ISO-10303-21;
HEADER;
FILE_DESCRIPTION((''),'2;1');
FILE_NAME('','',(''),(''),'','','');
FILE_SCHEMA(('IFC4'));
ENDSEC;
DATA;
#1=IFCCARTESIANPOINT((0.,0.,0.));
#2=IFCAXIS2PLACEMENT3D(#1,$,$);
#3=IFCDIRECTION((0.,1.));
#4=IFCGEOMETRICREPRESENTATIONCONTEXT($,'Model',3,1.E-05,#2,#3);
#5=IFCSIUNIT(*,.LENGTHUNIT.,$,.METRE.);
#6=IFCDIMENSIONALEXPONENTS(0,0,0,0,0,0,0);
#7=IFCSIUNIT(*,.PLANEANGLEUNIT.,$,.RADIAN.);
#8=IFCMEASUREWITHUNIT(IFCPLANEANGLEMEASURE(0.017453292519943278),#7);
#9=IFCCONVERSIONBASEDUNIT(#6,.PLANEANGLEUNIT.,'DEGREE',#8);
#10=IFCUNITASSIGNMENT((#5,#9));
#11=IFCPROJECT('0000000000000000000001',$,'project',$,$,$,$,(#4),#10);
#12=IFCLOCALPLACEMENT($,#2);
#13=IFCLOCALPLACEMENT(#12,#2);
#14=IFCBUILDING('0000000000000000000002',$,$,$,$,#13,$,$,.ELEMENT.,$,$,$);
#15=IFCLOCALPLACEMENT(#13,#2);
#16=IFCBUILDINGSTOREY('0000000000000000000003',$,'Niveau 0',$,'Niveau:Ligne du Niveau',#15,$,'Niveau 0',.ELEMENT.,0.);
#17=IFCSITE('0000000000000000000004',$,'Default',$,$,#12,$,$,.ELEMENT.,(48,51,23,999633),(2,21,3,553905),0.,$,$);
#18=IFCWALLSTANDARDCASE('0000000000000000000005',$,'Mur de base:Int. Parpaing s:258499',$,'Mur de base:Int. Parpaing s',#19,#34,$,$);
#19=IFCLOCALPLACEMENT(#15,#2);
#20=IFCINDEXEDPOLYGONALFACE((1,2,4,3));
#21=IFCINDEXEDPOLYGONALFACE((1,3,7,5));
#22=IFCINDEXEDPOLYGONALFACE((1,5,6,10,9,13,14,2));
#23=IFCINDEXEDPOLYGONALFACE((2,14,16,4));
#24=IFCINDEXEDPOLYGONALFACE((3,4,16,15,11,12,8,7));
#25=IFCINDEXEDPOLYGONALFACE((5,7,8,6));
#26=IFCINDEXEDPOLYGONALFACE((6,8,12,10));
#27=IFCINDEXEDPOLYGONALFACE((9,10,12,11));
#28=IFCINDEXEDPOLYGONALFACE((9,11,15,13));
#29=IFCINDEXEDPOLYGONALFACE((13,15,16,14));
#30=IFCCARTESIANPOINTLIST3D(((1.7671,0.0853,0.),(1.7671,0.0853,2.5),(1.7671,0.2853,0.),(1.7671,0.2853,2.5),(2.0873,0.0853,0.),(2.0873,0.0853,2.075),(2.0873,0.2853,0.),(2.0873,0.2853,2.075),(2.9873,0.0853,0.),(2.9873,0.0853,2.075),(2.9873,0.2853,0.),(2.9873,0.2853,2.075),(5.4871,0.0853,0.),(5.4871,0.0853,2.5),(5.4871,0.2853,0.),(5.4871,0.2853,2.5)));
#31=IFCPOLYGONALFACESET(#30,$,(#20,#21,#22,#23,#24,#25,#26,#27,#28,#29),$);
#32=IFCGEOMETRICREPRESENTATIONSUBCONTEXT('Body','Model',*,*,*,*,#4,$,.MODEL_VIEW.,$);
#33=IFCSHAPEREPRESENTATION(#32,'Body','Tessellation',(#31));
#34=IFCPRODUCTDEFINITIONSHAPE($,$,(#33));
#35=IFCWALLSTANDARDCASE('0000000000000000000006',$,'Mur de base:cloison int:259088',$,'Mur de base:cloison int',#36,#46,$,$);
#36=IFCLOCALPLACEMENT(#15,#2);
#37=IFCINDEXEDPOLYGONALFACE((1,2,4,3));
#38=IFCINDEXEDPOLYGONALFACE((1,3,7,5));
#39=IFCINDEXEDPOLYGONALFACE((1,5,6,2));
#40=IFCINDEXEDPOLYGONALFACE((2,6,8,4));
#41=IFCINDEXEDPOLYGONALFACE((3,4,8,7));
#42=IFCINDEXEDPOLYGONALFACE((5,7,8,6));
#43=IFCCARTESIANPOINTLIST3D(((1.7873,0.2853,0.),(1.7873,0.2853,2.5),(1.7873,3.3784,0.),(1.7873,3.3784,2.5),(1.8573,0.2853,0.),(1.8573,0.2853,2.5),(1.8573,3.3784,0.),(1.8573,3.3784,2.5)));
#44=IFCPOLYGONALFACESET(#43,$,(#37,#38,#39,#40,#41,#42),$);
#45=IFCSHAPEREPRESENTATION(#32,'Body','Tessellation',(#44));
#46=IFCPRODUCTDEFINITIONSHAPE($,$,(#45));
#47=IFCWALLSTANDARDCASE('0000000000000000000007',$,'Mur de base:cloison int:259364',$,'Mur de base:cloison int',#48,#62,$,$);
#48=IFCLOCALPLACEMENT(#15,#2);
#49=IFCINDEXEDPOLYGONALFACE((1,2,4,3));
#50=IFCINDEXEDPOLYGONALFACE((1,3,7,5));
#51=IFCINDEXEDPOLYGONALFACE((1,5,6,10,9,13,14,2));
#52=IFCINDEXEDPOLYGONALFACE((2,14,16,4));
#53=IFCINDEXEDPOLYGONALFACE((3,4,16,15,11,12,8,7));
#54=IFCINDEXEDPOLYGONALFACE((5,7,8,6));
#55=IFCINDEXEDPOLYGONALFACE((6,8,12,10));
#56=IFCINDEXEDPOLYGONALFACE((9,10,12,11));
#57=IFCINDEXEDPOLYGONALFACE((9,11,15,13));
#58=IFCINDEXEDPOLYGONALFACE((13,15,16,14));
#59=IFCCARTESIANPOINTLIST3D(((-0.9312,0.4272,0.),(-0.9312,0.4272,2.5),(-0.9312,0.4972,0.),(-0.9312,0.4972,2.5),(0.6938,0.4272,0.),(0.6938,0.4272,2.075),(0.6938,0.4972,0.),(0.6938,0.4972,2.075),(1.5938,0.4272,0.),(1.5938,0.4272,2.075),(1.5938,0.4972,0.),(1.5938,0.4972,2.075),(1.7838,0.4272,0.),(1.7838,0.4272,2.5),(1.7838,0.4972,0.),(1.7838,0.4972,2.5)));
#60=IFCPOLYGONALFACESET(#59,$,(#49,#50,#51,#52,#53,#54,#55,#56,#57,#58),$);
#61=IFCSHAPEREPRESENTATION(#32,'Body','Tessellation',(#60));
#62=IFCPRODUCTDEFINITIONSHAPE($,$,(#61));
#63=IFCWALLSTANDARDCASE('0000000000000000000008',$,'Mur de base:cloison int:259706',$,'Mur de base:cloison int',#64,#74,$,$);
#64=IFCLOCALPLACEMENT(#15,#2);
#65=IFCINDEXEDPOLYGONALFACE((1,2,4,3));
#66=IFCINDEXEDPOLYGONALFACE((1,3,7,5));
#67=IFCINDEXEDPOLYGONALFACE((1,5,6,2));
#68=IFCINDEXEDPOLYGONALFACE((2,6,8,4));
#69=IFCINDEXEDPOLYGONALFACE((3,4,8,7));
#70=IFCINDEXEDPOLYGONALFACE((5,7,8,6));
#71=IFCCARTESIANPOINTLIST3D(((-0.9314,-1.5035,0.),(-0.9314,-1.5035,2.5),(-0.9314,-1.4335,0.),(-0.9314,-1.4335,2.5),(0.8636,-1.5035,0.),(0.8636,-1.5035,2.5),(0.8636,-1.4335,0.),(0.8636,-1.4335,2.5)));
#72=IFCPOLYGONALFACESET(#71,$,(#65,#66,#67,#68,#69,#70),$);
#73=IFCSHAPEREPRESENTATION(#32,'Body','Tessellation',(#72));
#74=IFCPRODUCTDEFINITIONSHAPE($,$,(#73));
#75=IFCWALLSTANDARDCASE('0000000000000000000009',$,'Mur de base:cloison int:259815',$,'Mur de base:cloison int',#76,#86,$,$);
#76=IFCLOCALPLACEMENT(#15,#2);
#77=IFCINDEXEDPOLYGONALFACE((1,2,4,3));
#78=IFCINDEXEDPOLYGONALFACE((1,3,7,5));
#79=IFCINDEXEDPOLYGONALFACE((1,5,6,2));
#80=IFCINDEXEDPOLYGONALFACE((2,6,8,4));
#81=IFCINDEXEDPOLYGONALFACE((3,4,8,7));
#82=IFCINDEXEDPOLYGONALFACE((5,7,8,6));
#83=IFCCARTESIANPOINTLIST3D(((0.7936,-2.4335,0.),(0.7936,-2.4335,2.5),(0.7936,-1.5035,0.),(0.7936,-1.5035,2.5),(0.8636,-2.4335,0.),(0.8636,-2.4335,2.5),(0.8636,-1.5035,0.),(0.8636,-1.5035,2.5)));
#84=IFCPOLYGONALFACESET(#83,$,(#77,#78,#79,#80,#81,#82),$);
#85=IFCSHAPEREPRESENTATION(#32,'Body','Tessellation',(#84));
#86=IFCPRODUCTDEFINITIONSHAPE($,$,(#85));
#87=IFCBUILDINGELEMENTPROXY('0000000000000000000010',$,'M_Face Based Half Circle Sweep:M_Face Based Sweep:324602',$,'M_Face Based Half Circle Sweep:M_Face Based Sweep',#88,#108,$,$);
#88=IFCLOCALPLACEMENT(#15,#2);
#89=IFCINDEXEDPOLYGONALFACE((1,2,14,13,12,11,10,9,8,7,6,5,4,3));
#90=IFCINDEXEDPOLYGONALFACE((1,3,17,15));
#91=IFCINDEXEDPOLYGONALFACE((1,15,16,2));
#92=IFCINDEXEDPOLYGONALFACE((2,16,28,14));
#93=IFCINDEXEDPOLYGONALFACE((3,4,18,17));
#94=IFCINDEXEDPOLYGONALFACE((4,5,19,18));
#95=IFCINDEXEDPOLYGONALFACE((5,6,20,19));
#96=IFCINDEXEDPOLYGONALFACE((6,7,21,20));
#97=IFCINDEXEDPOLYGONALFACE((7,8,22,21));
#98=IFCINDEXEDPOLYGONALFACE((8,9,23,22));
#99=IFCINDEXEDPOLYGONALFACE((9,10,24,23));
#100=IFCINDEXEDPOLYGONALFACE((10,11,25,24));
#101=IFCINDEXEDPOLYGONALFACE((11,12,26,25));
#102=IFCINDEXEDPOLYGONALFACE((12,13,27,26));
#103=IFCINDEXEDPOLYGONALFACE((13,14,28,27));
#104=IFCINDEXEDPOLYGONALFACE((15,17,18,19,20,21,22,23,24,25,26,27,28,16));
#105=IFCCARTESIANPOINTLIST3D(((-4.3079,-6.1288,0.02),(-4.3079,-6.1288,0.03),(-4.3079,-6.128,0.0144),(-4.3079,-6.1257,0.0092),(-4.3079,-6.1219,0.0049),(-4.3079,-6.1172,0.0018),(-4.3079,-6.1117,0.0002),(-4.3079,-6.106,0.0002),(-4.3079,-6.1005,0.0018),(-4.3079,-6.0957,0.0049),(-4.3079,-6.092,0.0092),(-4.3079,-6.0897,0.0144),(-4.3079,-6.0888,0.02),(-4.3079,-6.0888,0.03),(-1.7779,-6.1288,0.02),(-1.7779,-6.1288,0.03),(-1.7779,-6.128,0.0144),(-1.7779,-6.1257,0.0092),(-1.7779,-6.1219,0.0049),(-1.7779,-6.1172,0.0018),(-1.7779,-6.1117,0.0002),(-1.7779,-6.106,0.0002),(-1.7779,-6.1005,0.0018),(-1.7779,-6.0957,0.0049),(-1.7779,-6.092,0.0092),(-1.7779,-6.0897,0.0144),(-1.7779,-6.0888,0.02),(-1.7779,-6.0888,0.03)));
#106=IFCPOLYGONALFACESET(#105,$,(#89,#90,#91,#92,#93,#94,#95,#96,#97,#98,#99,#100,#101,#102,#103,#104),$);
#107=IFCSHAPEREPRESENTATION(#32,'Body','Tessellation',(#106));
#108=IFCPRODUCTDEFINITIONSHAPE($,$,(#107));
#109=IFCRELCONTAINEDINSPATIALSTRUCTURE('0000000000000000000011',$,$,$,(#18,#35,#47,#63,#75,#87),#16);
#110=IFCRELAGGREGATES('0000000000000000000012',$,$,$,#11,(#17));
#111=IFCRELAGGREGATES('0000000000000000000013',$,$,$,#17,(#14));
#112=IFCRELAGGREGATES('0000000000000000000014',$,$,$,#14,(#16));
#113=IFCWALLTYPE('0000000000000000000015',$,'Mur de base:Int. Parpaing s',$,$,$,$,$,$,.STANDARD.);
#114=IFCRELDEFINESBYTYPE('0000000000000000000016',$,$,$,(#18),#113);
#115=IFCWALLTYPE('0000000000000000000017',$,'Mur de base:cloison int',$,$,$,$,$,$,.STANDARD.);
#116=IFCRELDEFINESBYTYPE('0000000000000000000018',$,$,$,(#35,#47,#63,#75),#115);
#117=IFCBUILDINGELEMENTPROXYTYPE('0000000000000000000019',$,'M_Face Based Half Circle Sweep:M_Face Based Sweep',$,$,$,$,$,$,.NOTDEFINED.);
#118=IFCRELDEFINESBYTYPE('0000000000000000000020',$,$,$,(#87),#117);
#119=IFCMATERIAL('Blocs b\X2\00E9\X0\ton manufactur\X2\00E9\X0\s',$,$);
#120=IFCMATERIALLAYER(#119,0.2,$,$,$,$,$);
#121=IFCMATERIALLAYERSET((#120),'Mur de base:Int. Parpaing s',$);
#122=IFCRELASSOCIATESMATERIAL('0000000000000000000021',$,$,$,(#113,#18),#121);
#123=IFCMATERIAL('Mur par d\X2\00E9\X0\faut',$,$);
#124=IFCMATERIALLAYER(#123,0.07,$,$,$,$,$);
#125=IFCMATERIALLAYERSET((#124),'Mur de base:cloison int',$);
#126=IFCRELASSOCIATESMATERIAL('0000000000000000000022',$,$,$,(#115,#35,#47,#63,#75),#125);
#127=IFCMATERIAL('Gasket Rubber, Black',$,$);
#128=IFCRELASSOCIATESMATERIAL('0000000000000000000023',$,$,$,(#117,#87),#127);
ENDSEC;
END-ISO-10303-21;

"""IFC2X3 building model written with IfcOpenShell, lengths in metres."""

from ifc_helpers import new_model, entity, si_unit, converted_unit, direction, frame, frame_2d, origin, place, context, subcontext, project, spatial, polyline, circle_curve, parameter, trimmed, segment, composite_curve, rectangle, outline, extrude, source, transform, mapped, material, layer, layer_set, layer_usage, type_object, type_shapes, element, save


model = new_model("IFC2X3")

# Units and contexts
model_context = context("Model", 3, precision=1e-05, world=origin(), true_north=direction((0.0, 1.0)))
body_context = subcontext(model_context, "Body", "Model", "MODEL_VIEW")
ifc_project = project(units=[si_unit("LENGTHUNIT", "METRE"), converted_unit("PLANEANGLEUNIT", "DEGREE", entity("IfcPlaneAngleMeasure", 0.017453292519943278), si_unit("PLANEANGLEUNIT", "RADIAN"), dimensions=[0, 0, 0, 0, 0, 0, 0])], contexts=[model_context])

# Site, building, storey
site_placement = place(None, origin())
site = spatial("IfcSite", under=ifc_project, at=site_placement, Name="Default", CompositionType="ELEMENT", RefLatitude=(48, 51, 23, 999633), RefLongitude=(2, 21, 3, 553905), RefElevation=0.0)
building_placement = place(site_placement, origin())
building = spatial("IfcBuilding", under=site, at=building_placement, CompositionType="ELEMENT")
storey_placement = place(building_placement, origin())
storey = spatial("IfcBuildingStorey", under=building, at=storey_placement, Name="Niveau 0", ObjectType="Niveau:Ligne du Niveau", LongName="Niveau 0", CompositionType="ELEMENT", Elevation=0.0)

# Shared definitions
ifc_material_1 = material(Name="Blocs béton manufacturés")

# Wall, opening
ifc_layer_1 = layer(ifc_material_1, 0.2)
ifc_layer_set_1 = layer_set([ifc_layer_1], Name="Mur de base:Int. Parpaing s")
ifc_layer_usage_1 = layer_usage(ifc_layer_set_1, "AXIS2", "POSITIVE", -0.1)
wall_type_1 = type_object("IfcWallType", Name="Mur de base:Int. Parpaing s", PredefinedType="STANDARD", material=ifc_layer_set_1)
wall_1_placement = place(storey_placement, frame((1.7671, 0.1853, 0.0)))
wall_1 = element("IfcWallStandardCase", 1, at=wall_1_placement, inside=storey, type_object=wall_type_1, material=ifc_layer_usage_1, Name="Mur de base:Int. Parpaing s:258499", ObjectType="Mur de base:Int. Parpaing s", context=body_context, shape_type="SweptSolid", body=[
    extrude(rectangle(XDim=3.72, YDim=0.2, at=frame_2d((1.86, 0.0), x_axis=(-1.0, 0.0))), origin(), (0.0, 0.0, 1.0), 2.5),
])
opening_1_placement = place(wall_1_placement, frame((1.2201, 0.1, 0.0)))
element("IfcOpeningElement", 2, at=opening_1_placement, cuts=wall_1, ObjectType="Opening", context=body_context, shape_type="SweptSolid", body=[
    extrude(rectangle(XDim=2.075, YDim=0.9, at=frame_2d((1.0375, 0.45), x_axis=(1.0, 0.0))), frame((0.0, 0.0, 0.0), z_axis=(0.0, -1.0, 0.0), x_axis=(0.0, 0.0, 1.0)), (0.0, 0.0, 1.0), 0.2),
])

# Wall
ifc_material_2 = material(Name="Mur par défaut")
ifc_layer_2 = layer(ifc_material_2, 0.07)
ifc_layer_set_2 = layer_set([ifc_layer_2], Name="Mur de base:cloison int")
ifc_layer_usage_2 = layer_usage(ifc_layer_set_2, "AXIS2", "POSITIVE", -0.035)
wall_type_2 = type_object("IfcWallType", Name="Mur de base:cloison int", PredefinedType="STANDARD", material=ifc_layer_set_2)
wall_2_placement = place(storey_placement, frame((1.8223, 3.3784, 0.0), z_axis=(0.0, 0.0, 1.0), x_axis=(0.0, -1.0, 0.0)))
element("IfcWallStandardCase", 3, at=wall_2_placement, inside=storey, type_object=wall_type_2, material=ifc_layer_usage_2, Name="Mur de base:cloison int:259088", ObjectType="Mur de base:cloison int", context=body_context, shape_type="SweptSolid", body=[
    extrude(rectangle(XDim=3.0931, YDim=0.07, at=frame_2d((1.5465, 0.0), x_axis=(-1.0, 0.0))), origin(), (0.0, 0.0, 1.0), 2.5),
])

# Wall, opening
ifc_layer_usage_3 = layer_usage(ifc_layer_set_2, "AXIS2", "POSITIVE", -0.035)
wall_3_placement = place(storey_placement, frame((1.7838, 0.4622, 0.0), z_axis=(0.0, 0.0, 1.0), x_axis=(-1.0, 0.0, 0.0)))
wall_3 = element("IfcWallStandardCase", 4, at=wall_3_placement, inside=storey, type_object=wall_type_2, material=ifc_layer_usage_3, Name="Mur de base:cloison int:259364", ObjectType="Mur de base:cloison int", context=body_context, shape_type="SweptSolid", body=[
    extrude(rectangle(XDim=2.715, YDim=0.07, at=frame_2d((1.3575, 0.0), x_axis=(-1.0, 0.0))), origin(), (0.0, 0.0, 1.0), 2.5),
])
opening_2_placement = place(wall_3_placement, frame((0.19, -0.035, 0.0)))
element("IfcOpeningElement", 5, at=opening_2_placement, cuts=wall_3, ObjectType="Opening", context=body_context, shape_type="SweptSolid", body=[
    extrude(rectangle(XDim=2.075, YDim=0.9, at=frame_2d((1.0375, 0.45), x_axis=(1.0, 0.0))), frame((0.0, 0.0, 0.0), z_axis=(0.0, 1.0, 0.0), x_axis=(0.0, 0.0, 1.0)), (0.0, 0.0, 1.0), 0.07),
])

# Walls
ifc_layer_usage_4 = layer_usage(ifc_layer_set_2, "AXIS2", "NEGATIVE", 0.035)
wall_4_placement = place(storey_placement, frame((-0.9314, -1.4685, 0.0)))
element("IfcWallStandardCase", 6, at=wall_4_placement, inside=storey, type_object=wall_type_2, material=ifc_layer_usage_4, Name="Mur de base:cloison int:259706", ObjectType="Mur de base:cloison int", context=body_context, shape_type="SweptSolid", body=[
    extrude(rectangle(XDim=1.795, YDim=0.07, at=frame_2d((0.8975, 0.0), x_axis=(-1.0, 0.0))), origin(), (0.0, 0.0, 1.0), 2.5),
])
ifc_layer_usage_5 = layer_usage(ifc_layer_set_2, "AXIS2", "NEGATIVE", 0.035)
wall_5_placement = place(storey_placement, frame((0.8286, -1.5035, 0.0), z_axis=(0.0, 0.0, 1.0), x_axis=(0.0, -1.0, 0.0)))
element("IfcWallStandardCase", 7, at=wall_5_placement, inside=storey, type_object=wall_type_2, material=ifc_layer_usage_5, Name="Mur de base:cloison int:259815", ObjectType="Mur de base:cloison int", context=body_context, shape_type="SweptSolid", body=[
    extrude(rectangle(XDim=0.93, YDim=0.07, at=frame_2d((0.465, 0.0), x_axis=(-1.0, 0.0))), origin(), (0.0, 0.0, 1.0), 2.5),
])

# Building element proxy
ifc_material_3 = material(Name="Gasket Rubber, Black")
building_element_proxy_type_1 = type_object("IfcBuildingElementProxyType", Name="M_Face Based Half Circle Sweep:M_Face Based Sweep", PredefinedType="NOTDEFINED", material=ifc_material_3)
shared_shape_1 = source(origin(), body_context, "Body", "SweptSolid", [
    extrude(outline(composite_curve([segment(polyline([(-0.005, -0.02), (0.005, -0.02)]), True, "CONTINUOUS"), segment(trimmed(circle_curve(frame_2d((0.005, 0.0), x_axis=(0.0, -1.0)), 0.02), [parameter(360.0)], [parameter(180.0)], True, "PARAMETER"), True, "CONTINUOUS"), segment(polyline([(0.005, 0.02), (-0.005, 0.02)]), True, "CONTINUOUS"), segment(polyline([(-0.005, 0.02), (-0.005, -0.02)]), True, "CONTINUOUS")], self_intersect=False)), frame((-1.265, 0.0, 0.005), z_axis=(1.0, 0.0, 0.0), x_axis=(0.0, 0.0, 1.0)), (0.0, 0.0, 1.0), 2.53),
])
type_shapes(building_element_proxy_type_1, [shared_shape_1])
proxy_1_placement = place(storey_placement, frame((-3.0429, -6.1088, 0.03), z_axis=(0.0, 0.0, -1.0), x_axis=(-1.0, 0.0, 0.0)))
element("IfcBuildingElementProxy", 8, at=proxy_1_placement, inside=storey, type_object=building_element_proxy_type_1, material=ifc_material_3, Name="M_Face Based Half Circle Sweep:M_Face Based Sweep:324602", ObjectType="M_Face Based Half Circle Sweep:M_Face Based Sweep", context=body_context, shape_type="MappedRepresentation", body=[
    mapped(shared_shape_1, transform((0.0, 0.0, 0.0), scale=1.0)),
])

save(model, "model.ifc")
